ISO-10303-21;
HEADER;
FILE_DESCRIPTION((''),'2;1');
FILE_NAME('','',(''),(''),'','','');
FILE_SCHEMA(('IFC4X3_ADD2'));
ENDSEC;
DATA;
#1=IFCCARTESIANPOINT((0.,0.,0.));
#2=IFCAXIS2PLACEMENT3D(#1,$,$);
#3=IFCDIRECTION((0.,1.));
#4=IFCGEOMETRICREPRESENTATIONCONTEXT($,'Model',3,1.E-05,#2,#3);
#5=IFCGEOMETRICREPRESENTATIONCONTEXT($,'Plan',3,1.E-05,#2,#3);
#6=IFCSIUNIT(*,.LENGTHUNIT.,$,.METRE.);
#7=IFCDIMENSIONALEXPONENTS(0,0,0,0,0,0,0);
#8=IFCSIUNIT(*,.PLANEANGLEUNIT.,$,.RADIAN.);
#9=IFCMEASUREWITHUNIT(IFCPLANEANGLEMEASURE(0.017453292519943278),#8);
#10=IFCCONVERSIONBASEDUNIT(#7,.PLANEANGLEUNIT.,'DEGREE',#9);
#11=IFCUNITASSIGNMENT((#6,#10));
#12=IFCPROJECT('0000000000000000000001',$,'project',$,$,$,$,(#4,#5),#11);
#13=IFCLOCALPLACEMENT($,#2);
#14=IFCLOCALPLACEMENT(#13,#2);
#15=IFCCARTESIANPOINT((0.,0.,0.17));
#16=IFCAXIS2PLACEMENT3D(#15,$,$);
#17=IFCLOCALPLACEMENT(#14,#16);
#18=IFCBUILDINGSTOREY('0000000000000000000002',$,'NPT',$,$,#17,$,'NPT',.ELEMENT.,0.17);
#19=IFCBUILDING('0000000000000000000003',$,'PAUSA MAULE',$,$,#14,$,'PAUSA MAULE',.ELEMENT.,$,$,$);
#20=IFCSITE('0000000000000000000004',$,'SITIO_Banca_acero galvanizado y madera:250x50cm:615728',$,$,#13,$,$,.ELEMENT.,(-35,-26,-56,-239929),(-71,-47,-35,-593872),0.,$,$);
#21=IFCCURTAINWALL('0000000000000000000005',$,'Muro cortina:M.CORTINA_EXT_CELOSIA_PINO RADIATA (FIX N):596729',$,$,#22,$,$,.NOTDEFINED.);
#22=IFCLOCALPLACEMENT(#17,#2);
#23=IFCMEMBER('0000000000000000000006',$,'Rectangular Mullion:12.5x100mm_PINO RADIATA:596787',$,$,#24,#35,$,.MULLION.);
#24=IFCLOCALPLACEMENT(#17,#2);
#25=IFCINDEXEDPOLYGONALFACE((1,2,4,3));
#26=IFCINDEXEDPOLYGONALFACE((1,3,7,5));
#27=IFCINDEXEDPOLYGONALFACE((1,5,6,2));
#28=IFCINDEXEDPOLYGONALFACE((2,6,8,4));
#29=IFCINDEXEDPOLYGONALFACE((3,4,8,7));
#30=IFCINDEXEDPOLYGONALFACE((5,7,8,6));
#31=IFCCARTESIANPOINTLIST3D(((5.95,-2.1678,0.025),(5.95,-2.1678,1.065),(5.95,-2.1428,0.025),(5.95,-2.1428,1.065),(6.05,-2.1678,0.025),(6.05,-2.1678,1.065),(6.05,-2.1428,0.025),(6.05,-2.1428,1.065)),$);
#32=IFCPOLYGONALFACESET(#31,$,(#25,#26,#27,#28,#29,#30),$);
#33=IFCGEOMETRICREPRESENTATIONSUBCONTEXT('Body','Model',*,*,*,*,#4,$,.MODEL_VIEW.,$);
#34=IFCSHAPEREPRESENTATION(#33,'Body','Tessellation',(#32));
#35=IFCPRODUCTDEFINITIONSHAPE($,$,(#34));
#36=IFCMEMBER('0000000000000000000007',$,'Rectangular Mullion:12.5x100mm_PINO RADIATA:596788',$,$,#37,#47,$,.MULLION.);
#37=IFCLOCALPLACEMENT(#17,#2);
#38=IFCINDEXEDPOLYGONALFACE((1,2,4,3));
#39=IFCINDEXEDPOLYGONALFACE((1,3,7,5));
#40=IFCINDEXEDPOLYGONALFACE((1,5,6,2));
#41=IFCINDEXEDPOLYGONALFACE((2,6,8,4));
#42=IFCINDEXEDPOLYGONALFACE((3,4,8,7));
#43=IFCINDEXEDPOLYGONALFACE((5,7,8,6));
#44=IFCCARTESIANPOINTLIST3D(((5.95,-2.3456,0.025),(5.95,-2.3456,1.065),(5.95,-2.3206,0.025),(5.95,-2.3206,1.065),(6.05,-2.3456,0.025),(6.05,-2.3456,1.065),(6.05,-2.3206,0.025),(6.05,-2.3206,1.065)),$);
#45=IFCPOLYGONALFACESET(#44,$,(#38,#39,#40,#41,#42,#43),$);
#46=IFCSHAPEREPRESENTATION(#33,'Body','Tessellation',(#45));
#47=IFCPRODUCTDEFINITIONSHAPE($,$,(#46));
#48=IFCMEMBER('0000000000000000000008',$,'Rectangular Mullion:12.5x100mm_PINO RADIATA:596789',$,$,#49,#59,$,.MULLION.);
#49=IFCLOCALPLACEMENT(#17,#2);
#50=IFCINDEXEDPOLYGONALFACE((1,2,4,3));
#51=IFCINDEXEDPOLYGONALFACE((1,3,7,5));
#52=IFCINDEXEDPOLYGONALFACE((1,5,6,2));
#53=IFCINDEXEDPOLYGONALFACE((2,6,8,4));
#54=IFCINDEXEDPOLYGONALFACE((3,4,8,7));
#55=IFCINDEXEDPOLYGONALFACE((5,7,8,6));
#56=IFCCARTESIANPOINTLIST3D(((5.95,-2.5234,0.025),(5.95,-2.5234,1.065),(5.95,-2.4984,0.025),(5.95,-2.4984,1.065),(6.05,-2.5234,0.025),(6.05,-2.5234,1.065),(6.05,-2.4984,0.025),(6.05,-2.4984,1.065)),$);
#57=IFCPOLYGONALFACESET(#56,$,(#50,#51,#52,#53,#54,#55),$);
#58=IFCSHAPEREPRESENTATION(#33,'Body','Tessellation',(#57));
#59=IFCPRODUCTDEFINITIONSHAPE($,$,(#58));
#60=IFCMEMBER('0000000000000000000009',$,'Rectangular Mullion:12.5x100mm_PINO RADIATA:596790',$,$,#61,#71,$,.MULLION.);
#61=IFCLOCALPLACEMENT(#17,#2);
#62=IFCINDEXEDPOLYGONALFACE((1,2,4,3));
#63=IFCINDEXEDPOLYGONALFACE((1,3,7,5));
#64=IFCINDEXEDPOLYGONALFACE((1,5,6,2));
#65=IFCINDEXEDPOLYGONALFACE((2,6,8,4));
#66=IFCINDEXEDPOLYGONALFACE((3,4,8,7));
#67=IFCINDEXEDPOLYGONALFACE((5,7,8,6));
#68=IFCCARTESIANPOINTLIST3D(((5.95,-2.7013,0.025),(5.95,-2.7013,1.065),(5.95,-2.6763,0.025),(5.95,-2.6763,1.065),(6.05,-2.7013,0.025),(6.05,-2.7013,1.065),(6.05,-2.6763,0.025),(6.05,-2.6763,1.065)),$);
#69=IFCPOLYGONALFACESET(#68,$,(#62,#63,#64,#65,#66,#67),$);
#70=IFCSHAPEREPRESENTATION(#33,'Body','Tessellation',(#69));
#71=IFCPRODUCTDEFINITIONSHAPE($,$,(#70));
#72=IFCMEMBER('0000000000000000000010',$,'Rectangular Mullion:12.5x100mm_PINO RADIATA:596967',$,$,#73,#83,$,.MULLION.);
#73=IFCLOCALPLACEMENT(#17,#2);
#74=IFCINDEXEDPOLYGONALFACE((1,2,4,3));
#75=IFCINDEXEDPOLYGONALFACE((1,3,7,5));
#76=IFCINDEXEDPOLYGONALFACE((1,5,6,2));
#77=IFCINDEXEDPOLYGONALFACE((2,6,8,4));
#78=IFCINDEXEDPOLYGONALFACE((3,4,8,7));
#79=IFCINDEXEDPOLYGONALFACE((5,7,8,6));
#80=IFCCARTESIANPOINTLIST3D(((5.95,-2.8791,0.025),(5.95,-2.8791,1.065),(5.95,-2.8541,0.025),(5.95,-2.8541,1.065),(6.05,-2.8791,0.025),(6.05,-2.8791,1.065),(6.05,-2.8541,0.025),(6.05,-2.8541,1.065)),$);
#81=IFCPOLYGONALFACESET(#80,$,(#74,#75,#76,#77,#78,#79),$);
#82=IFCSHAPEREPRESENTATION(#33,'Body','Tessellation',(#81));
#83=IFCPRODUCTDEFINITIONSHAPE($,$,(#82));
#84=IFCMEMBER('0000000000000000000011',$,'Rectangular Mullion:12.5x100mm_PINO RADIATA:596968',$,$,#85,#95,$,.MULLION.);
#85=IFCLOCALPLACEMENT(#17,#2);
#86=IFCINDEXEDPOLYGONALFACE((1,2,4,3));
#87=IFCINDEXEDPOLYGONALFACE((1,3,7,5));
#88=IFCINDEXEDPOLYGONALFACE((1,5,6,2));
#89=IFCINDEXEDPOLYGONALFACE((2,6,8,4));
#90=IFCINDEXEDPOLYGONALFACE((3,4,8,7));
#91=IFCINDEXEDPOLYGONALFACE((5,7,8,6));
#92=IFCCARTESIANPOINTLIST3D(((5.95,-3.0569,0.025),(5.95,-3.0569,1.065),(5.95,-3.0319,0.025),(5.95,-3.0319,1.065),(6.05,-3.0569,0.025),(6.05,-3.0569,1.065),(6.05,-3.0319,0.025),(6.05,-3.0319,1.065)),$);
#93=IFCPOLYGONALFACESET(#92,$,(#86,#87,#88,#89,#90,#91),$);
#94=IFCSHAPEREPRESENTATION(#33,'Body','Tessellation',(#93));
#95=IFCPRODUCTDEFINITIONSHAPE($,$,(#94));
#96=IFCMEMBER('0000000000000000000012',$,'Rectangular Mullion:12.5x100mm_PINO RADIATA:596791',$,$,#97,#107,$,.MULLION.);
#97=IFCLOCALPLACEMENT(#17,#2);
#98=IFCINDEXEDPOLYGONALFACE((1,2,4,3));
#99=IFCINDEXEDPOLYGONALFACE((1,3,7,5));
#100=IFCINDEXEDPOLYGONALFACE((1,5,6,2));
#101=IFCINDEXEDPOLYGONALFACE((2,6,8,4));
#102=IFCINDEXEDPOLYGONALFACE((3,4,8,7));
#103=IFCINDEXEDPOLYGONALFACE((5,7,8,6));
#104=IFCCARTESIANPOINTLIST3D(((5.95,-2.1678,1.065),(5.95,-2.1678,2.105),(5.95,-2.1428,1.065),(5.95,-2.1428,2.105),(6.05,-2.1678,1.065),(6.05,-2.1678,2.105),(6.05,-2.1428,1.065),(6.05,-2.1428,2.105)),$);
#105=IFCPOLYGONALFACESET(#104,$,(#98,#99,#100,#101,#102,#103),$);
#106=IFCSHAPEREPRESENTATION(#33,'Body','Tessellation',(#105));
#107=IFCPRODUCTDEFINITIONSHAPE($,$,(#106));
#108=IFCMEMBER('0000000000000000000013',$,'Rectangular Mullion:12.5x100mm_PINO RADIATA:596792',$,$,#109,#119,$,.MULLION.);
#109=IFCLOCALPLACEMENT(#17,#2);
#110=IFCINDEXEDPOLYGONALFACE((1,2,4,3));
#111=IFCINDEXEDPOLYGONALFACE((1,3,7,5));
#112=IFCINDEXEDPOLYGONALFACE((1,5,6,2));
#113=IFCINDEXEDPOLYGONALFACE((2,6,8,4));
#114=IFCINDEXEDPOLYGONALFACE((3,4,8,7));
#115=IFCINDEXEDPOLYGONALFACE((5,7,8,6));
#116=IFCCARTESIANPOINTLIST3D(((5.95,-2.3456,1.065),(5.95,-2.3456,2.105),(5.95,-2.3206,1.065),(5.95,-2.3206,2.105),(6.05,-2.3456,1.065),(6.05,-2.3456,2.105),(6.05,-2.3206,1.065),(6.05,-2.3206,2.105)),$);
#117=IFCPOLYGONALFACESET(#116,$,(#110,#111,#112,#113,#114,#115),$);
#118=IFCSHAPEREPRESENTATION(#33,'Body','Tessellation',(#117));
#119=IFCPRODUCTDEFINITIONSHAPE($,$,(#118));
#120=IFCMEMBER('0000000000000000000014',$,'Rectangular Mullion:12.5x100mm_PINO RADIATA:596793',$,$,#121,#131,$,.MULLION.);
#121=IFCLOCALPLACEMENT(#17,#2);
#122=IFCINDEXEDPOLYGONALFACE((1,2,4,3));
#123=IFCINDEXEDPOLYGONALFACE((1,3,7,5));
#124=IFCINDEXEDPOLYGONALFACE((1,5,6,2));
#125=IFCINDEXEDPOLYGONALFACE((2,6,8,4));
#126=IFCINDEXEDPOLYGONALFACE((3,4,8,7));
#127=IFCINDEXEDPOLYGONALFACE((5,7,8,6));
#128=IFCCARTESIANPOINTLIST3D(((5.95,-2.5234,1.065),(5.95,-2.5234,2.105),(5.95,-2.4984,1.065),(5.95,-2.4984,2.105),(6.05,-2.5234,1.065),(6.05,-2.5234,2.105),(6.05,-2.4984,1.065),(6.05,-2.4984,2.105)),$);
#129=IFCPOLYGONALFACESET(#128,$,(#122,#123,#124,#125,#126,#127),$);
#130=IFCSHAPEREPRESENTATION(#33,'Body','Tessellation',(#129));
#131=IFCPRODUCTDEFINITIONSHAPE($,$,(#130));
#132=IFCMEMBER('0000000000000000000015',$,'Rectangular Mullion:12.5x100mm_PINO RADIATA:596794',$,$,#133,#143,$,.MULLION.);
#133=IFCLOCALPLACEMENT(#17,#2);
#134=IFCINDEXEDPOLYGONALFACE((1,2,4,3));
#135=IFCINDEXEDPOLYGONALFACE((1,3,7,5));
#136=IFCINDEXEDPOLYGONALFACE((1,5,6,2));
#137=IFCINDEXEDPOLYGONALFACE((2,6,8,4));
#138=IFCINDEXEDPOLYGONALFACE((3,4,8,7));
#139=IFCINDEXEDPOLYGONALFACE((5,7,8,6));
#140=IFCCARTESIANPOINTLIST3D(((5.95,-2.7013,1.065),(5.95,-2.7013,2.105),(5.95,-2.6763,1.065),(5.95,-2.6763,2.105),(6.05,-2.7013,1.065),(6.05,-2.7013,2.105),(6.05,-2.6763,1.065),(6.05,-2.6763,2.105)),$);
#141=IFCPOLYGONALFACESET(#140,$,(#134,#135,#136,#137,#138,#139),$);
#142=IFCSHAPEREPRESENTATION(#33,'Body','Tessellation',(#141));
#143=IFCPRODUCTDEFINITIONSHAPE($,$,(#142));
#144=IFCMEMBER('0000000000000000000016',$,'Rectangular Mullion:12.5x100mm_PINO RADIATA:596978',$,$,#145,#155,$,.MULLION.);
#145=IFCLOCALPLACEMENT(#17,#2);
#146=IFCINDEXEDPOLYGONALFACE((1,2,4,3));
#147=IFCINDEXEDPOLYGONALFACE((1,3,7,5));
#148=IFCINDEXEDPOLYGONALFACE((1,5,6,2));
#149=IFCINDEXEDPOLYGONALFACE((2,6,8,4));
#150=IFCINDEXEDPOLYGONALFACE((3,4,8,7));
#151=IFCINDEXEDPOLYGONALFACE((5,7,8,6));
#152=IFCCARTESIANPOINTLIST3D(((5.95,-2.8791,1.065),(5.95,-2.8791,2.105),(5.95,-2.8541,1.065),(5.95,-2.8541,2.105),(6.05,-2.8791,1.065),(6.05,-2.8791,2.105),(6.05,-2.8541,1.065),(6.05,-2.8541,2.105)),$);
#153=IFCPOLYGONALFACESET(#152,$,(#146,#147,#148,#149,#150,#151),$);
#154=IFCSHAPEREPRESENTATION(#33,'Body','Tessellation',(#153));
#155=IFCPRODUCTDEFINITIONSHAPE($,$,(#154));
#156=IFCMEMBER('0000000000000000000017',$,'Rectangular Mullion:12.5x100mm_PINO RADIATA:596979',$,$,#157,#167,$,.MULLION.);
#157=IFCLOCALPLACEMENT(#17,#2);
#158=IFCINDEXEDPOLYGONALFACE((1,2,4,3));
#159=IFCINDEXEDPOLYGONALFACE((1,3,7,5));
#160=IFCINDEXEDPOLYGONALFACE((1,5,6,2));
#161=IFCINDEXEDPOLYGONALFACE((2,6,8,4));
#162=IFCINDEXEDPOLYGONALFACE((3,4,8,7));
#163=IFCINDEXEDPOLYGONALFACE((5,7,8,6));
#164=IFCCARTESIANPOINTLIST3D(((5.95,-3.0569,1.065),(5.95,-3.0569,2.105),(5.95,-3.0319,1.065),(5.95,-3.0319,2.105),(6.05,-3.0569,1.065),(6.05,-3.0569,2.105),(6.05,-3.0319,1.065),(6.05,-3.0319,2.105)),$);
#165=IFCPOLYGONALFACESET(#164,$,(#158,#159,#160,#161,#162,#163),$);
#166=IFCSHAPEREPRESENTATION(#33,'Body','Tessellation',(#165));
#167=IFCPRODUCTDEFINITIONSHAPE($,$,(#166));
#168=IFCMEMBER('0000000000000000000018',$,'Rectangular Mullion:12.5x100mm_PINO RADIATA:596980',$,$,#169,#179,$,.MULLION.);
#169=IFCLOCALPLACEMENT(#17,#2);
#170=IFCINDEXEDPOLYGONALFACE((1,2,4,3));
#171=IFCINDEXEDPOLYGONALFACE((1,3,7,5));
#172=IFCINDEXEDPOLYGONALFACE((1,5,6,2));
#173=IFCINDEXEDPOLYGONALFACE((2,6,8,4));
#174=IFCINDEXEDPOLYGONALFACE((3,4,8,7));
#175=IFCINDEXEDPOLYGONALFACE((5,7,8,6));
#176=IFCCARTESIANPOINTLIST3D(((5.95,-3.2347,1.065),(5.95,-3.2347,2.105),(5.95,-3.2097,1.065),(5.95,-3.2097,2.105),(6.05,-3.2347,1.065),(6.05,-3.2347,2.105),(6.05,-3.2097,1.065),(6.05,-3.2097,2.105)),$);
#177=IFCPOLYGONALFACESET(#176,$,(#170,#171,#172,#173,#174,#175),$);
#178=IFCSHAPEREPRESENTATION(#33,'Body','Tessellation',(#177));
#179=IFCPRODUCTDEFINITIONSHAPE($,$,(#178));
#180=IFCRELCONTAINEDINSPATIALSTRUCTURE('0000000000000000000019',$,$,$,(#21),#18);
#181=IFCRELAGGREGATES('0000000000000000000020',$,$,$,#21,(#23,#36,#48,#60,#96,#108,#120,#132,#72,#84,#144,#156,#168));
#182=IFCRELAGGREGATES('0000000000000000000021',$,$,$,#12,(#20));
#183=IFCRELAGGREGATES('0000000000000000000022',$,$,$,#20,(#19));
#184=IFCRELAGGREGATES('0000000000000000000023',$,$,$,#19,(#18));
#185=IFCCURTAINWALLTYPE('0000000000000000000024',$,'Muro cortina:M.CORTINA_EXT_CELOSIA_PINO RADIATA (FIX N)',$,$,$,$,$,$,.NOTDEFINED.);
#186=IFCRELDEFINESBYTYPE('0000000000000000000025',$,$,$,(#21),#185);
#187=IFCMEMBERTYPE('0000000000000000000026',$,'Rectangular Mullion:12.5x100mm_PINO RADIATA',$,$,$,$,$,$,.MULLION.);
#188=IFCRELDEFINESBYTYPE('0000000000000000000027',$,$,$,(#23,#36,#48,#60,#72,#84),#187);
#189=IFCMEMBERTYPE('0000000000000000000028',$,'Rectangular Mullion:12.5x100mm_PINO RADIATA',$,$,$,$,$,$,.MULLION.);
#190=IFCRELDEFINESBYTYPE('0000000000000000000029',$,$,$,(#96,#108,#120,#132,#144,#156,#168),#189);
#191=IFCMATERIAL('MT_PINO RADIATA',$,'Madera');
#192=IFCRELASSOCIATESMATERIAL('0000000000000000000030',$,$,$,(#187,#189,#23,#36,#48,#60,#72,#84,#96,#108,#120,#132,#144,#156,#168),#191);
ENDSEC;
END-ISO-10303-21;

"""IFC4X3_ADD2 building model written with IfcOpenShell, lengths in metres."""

from ifc_helpers import new_model, entity, si_unit, converted_unit, direction, frame, frame_2d, origin, origin_2d_with_axis, place, context, subcontext, project, spatial, rectangle, extrude, source, transform, mapped, material, material_profile, profile_set, profile_usage, type_object, type_shapes, element, aggregate, save


model = new_model("IFC4X3_ADD2")

# Units and contexts
model_context = context("Model", 3, precision=1e-05, world=origin(), true_north=direction((0.0, 1.0)))
plan_context = context("Plan", 3, precision=1e-05, world=origin(), true_north=direction((0.0, 1.0)))
body_context = subcontext(model_context, "Body", "Model", "MODEL_VIEW")
ifc_project = project(units=[si_unit("LENGTHUNIT", "METRE"), converted_unit("PLANEANGLEUNIT", "DEGREE", entity("IfcPlaneAngleMeasure", 0.017453292519943278), si_unit("PLANEANGLEUNIT", "RADIAN"), dimensions=[0, 0, 0, 0, 0, 0, 0])], contexts=[model_context, plan_context])

# Site, building, storey
site_placement = place(None, origin())
site = spatial("IfcSite", under=ifc_project, at=site_placement, Name="SITIO_Banca_acero galvanizado y madera:250x50cm:615728", CompositionType="ELEMENT", RefLatitude=(-35, -26, -56, -239929), RefLongitude=(-71, -47, -35, -593872), RefElevation=0.0)
building_placement = place(site_placement, origin())
building = spatial("IfcBuilding", under=site, at=building_placement, Name="PAUSA MAULE", LongName="PAUSA MAULE", CompositionType="ELEMENT")
storey_placement = place(building_placement, frame((0.0, 0.0, 0.17)))
storey = spatial("IfcBuildingStorey", under=building, at=storey_placement, Name="NPT", LongName="NPT", CompositionType="ELEMENT", Elevation=0.17)

# Curtain wall, members
curtain_wall_type = type_object("IfcCurtainWallType", Name="Muro cortina:M.CORTINA_EXT_CELOSIA_PINO RADIATA (FIX N)", PredefinedType="NOTDEFINED")
curtain_wall_placement = place(storey_placement, frame((0.0, 0.0, -0.17)))
curtain_wall = element("IfcCurtainWall", 1, at=curtain_wall_placement, inside=storey, type_object=curtain_wall_type, Name="Muro cortina:M.CORTINA_EXT_CELOSIA_PINO RADIATA (FIX N):596729", PredefinedType="NOTDEFINED")
ifc_material = material(Name="MT_PINO RADIATA", Category="Madera")
ifc_material_profile = material_profile(ifc_material, rectangle(XDim=0.025, YDim=0.1, at=frame_2d((0.0, 0.0), x_axis=(1.0, 0.0))), Name="12.5x100mm_PINO RADIATA")
ifc_profile_set = profile_set([ifc_material_profile], Name="12.5x100mm_PINO RADIATA")
ifc_profile_usage = profile_usage(ifc_profile_set)
member_type_1 = type_object("IfcMemberType", Name="Rectangular Mullion:12.5x100mm_PINO RADIATA", PredefinedType="MULLION", material=ifc_profile_set)
shared_shape_1 = source(origin(), body_context, "Body", "SweptSolid", [
    extrude(rectangle(XDim=0.025, YDim=0.1, at=frame_2d((0.0, 0.0), x_axis=(1.0, 0.0))), frame((0.0, 0.0, -1.04), z_axis=(0.0, 0.0, 1.0), x_axis=(-1.0, 0.0, 0.0)), (0.0, 0.0, 1.0), 1.04),
])
type_shapes(member_type_1, [shared_shape_1])
member_1_placement = place(curtain_wall_placement, frame((6.0, -2.1553, 0.195), z_axis=(0.0, 0.0, -1.0), x_axis=(0.0, -1.0, 0.0)))
member_1 = element("IfcMember", 2, at=member_1_placement, type_object=member_type_1, material=ifc_profile_usage, Name="Rectangular Mullion:12.5x100mm_PINO RADIATA:596787", PredefinedType="MULLION", context=body_context, shape_type="MappedRepresentation", body=[
    mapped(shared_shape_1, transform((0.0, 0.0, 0.0), scale=1.0)),
])
member_2_placement = place(curtain_wall_placement, frame((6.0, -2.3331, 0.195), z_axis=(0.0, 0.0, -1.0), x_axis=(0.0, -1.0, 0.0)))
member_2 = element("IfcMember", 3, at=member_2_placement, type_object=member_type_1, material=ifc_profile_usage, Name="Rectangular Mullion:12.5x100mm_PINO RADIATA:596788", PredefinedType="MULLION", context=body_context, shape_type="MappedRepresentation", body=[
    mapped(shared_shape_1, transform((0.0, 0.0, 0.0), scale=1.0)),
])
member_3_placement = place(curtain_wall_placement, frame((6.0, -2.5109, 0.195), z_axis=(0.0, 0.0, -1.0), x_axis=(0.0, -1.0, 0.0)))
member_3 = element("IfcMember", 4, at=member_3_placement, type_object=member_type_1, material=ifc_profile_usage, Name="Rectangular Mullion:12.5x100mm_PINO RADIATA:596789", PredefinedType="MULLION", context=body_context, shape_type="MappedRepresentation", body=[
    mapped(shared_shape_1, transform((0.0, 0.0, 0.0), scale=1.0)),
])
member_4_placement = place(curtain_wall_placement, frame((6.0, -2.6888, 0.195), z_axis=(0.0, 0.0, -1.0), x_axis=(0.0, -1.0, 0.0)))
member_4 = element("IfcMember", 5, at=member_4_placement, type_object=member_type_1, material=ifc_profile_usage, Name="Rectangular Mullion:12.5x100mm_PINO RADIATA:596790", PredefinedType="MULLION", context=body_context, shape_type="MappedRepresentation", body=[
    mapped(shared_shape_1, transform((0.0, 0.0, 0.0), scale=1.0)),
])
member_5_placement = place(curtain_wall_placement, frame((6.0, -2.8666, 0.195), z_axis=(0.0, 0.0, -1.0), x_axis=(0.0, -1.0, 0.0)))
member_5 = element("IfcMember", 6, at=member_5_placement, type_object=member_type_1, material=ifc_profile_usage, Name="Rectangular Mullion:12.5x100mm_PINO RADIATA:596967", PredefinedType="MULLION", context=body_context, shape_type="MappedRepresentation", body=[
    mapped(shared_shape_1, transform((0.0, 0.0, 0.0), scale=1.0)),
])
member_6_placement = place(curtain_wall_placement, frame((6.0, -3.0444, 0.195), z_axis=(0.0, 0.0, -1.0), x_axis=(0.0, -1.0, 0.0)))
member_6 = element("IfcMember", 7, at=member_6_placement, type_object=member_type_1, material=ifc_profile_usage, Name="Rectangular Mullion:12.5x100mm_PINO RADIATA:596968", PredefinedType="MULLION", context=body_context, shape_type="MappedRepresentation", body=[
    mapped(shared_shape_1, transform((0.0, 0.0, 0.0), scale=1.0)),
])
member_type_2 = type_object("IfcMemberType", Name="Rectangular Mullion:12.5x100mm_PINO RADIATA", PredefinedType="MULLION", material=ifc_profile_set)
shared_shape_2 = source(origin(), body_context, "Body", "SweptSolid", [
    extrude(rectangle(XDim=0.025, YDim=0.1, at=origin_2d_with_axis()), frame((0.0, 0.0, -1.04), z_axis=(0.0, 0.0, 1.0), x_axis=(-1.0, 0.0, 0.0)), (0.0, 0.0, 1.0), 1.04),
])
type_shapes(member_type_2, [shared_shape_2])
member_7_placement = place(curtain_wall_placement, frame((6.0, -2.1553, 1.235), z_axis=(0.0, 0.0, -1.0), x_axis=(0.0, -1.0, 0.0)))
member_7 = element("IfcMember", 8, at=member_7_placement, type_object=member_type_2, material=ifc_profile_usage, Name="Rectangular Mullion:12.5x100mm_PINO RADIATA:596791", PredefinedType="MULLION", context=body_context, shape_type="MappedRepresentation", body=[
    mapped(shared_shape_2, transform((0.0, 0.0, 0.0), scale=1.0)),
])
member_8_placement = place(curtain_wall_placement, frame((6.0, -2.3331, 1.235), z_axis=(0.0, 0.0, -1.0), x_axis=(0.0, -1.0, 0.0)))
member_8 = element("IfcMember", 9, at=member_8_placement, type_object=member_type_2, material=ifc_profile_usage, Name="Rectangular Mullion:12.5x100mm_PINO RADIATA:596792", PredefinedType="MULLION", context=body_context, shape_type="MappedRepresentation", body=[
    mapped(shared_shape_2, transform((0.0, 0.0, 0.0), scale=1.0)),
])
member_9_placement = place(curtain_wall_placement, frame((6.0, -2.5109, 1.235), z_axis=(0.0, 0.0, -1.0), x_axis=(0.0, -1.0, 0.0)))
member_9 = element("IfcMember", 10, at=member_9_placement, type_object=member_type_2, material=ifc_profile_usage, Name="Rectangular Mullion:12.5x100mm_PINO RADIATA:596793", PredefinedType="MULLION", context=body_context, shape_type="MappedRepresentation", body=[
    mapped(shared_shape_2, transform((0.0, 0.0, 0.0), scale=1.0)),
])
member_10_placement = place(curtain_wall_placement, frame((6.0, -2.6888, 1.235), z_axis=(0.0, 0.0, -1.0), x_axis=(0.0, -1.0, 0.0)))
member_10 = element("IfcMember", 11, at=member_10_placement, type_object=member_type_2, material=ifc_profile_usage, Name="Rectangular Mullion:12.5x100mm_PINO RADIATA:596794", PredefinedType="MULLION", context=body_context, shape_type="MappedRepresentation", body=[
    mapped(shared_shape_2, transform((0.0, 0.0, 0.0), scale=1.0)),
])
member_11_placement = place(curtain_wall_placement, frame((6.0, -2.8666, 1.235), z_axis=(0.0, 0.0, -1.0), x_axis=(0.0, -1.0, 0.0)))
member_11 = element("IfcMember", 12, at=member_11_placement, type_object=member_type_2, material=ifc_profile_usage, Name="Rectangular Mullion:12.5x100mm_PINO RADIATA:596978", PredefinedType="MULLION", context=body_context, shape_type="MappedRepresentation", body=[
    mapped(shared_shape_2, transform((0.0, 0.0, 0.0), scale=1.0)),
])
member_12_placement = place(curtain_wall_placement, frame((6.0, -3.0444, 1.235), z_axis=(0.0, 0.0, -1.0), x_axis=(0.0, -1.0, 0.0)))
member_12 = element("IfcMember", 13, at=member_12_placement, type_object=member_type_2, material=ifc_profile_usage, Name="Rectangular Mullion:12.5x100mm_PINO RADIATA:596979", PredefinedType="MULLION", context=body_context, shape_type="MappedRepresentation", body=[
    mapped(shared_shape_2, transform((0.0, 0.0, 0.0), scale=1.0)),
])
member_13_placement = place(curtain_wall_placement, frame((6.0, -3.2222, 1.235), z_axis=(0.0, 0.0, -1.0), x_axis=(0.0, -1.0, 0.0)))
member_13 = element("IfcMember", 14, at=member_13_placement, type_object=member_type_2, material=ifc_profile_usage, Name="Rectangular Mullion:12.5x100mm_PINO RADIATA:596980", PredefinedType="MULLION", context=body_context, shape_type="MappedRepresentation", body=[
    mapped(shared_shape_2, transform((0.0, 0.0, 0.0), scale=1.0)),
])
aggregate(curtain_wall, [member_1, member_2, member_3, member_4, member_7, member_8, member_9, member_10, member_5, member_6, member_11, member_12, member_13])

save(model, "model.ifc")
